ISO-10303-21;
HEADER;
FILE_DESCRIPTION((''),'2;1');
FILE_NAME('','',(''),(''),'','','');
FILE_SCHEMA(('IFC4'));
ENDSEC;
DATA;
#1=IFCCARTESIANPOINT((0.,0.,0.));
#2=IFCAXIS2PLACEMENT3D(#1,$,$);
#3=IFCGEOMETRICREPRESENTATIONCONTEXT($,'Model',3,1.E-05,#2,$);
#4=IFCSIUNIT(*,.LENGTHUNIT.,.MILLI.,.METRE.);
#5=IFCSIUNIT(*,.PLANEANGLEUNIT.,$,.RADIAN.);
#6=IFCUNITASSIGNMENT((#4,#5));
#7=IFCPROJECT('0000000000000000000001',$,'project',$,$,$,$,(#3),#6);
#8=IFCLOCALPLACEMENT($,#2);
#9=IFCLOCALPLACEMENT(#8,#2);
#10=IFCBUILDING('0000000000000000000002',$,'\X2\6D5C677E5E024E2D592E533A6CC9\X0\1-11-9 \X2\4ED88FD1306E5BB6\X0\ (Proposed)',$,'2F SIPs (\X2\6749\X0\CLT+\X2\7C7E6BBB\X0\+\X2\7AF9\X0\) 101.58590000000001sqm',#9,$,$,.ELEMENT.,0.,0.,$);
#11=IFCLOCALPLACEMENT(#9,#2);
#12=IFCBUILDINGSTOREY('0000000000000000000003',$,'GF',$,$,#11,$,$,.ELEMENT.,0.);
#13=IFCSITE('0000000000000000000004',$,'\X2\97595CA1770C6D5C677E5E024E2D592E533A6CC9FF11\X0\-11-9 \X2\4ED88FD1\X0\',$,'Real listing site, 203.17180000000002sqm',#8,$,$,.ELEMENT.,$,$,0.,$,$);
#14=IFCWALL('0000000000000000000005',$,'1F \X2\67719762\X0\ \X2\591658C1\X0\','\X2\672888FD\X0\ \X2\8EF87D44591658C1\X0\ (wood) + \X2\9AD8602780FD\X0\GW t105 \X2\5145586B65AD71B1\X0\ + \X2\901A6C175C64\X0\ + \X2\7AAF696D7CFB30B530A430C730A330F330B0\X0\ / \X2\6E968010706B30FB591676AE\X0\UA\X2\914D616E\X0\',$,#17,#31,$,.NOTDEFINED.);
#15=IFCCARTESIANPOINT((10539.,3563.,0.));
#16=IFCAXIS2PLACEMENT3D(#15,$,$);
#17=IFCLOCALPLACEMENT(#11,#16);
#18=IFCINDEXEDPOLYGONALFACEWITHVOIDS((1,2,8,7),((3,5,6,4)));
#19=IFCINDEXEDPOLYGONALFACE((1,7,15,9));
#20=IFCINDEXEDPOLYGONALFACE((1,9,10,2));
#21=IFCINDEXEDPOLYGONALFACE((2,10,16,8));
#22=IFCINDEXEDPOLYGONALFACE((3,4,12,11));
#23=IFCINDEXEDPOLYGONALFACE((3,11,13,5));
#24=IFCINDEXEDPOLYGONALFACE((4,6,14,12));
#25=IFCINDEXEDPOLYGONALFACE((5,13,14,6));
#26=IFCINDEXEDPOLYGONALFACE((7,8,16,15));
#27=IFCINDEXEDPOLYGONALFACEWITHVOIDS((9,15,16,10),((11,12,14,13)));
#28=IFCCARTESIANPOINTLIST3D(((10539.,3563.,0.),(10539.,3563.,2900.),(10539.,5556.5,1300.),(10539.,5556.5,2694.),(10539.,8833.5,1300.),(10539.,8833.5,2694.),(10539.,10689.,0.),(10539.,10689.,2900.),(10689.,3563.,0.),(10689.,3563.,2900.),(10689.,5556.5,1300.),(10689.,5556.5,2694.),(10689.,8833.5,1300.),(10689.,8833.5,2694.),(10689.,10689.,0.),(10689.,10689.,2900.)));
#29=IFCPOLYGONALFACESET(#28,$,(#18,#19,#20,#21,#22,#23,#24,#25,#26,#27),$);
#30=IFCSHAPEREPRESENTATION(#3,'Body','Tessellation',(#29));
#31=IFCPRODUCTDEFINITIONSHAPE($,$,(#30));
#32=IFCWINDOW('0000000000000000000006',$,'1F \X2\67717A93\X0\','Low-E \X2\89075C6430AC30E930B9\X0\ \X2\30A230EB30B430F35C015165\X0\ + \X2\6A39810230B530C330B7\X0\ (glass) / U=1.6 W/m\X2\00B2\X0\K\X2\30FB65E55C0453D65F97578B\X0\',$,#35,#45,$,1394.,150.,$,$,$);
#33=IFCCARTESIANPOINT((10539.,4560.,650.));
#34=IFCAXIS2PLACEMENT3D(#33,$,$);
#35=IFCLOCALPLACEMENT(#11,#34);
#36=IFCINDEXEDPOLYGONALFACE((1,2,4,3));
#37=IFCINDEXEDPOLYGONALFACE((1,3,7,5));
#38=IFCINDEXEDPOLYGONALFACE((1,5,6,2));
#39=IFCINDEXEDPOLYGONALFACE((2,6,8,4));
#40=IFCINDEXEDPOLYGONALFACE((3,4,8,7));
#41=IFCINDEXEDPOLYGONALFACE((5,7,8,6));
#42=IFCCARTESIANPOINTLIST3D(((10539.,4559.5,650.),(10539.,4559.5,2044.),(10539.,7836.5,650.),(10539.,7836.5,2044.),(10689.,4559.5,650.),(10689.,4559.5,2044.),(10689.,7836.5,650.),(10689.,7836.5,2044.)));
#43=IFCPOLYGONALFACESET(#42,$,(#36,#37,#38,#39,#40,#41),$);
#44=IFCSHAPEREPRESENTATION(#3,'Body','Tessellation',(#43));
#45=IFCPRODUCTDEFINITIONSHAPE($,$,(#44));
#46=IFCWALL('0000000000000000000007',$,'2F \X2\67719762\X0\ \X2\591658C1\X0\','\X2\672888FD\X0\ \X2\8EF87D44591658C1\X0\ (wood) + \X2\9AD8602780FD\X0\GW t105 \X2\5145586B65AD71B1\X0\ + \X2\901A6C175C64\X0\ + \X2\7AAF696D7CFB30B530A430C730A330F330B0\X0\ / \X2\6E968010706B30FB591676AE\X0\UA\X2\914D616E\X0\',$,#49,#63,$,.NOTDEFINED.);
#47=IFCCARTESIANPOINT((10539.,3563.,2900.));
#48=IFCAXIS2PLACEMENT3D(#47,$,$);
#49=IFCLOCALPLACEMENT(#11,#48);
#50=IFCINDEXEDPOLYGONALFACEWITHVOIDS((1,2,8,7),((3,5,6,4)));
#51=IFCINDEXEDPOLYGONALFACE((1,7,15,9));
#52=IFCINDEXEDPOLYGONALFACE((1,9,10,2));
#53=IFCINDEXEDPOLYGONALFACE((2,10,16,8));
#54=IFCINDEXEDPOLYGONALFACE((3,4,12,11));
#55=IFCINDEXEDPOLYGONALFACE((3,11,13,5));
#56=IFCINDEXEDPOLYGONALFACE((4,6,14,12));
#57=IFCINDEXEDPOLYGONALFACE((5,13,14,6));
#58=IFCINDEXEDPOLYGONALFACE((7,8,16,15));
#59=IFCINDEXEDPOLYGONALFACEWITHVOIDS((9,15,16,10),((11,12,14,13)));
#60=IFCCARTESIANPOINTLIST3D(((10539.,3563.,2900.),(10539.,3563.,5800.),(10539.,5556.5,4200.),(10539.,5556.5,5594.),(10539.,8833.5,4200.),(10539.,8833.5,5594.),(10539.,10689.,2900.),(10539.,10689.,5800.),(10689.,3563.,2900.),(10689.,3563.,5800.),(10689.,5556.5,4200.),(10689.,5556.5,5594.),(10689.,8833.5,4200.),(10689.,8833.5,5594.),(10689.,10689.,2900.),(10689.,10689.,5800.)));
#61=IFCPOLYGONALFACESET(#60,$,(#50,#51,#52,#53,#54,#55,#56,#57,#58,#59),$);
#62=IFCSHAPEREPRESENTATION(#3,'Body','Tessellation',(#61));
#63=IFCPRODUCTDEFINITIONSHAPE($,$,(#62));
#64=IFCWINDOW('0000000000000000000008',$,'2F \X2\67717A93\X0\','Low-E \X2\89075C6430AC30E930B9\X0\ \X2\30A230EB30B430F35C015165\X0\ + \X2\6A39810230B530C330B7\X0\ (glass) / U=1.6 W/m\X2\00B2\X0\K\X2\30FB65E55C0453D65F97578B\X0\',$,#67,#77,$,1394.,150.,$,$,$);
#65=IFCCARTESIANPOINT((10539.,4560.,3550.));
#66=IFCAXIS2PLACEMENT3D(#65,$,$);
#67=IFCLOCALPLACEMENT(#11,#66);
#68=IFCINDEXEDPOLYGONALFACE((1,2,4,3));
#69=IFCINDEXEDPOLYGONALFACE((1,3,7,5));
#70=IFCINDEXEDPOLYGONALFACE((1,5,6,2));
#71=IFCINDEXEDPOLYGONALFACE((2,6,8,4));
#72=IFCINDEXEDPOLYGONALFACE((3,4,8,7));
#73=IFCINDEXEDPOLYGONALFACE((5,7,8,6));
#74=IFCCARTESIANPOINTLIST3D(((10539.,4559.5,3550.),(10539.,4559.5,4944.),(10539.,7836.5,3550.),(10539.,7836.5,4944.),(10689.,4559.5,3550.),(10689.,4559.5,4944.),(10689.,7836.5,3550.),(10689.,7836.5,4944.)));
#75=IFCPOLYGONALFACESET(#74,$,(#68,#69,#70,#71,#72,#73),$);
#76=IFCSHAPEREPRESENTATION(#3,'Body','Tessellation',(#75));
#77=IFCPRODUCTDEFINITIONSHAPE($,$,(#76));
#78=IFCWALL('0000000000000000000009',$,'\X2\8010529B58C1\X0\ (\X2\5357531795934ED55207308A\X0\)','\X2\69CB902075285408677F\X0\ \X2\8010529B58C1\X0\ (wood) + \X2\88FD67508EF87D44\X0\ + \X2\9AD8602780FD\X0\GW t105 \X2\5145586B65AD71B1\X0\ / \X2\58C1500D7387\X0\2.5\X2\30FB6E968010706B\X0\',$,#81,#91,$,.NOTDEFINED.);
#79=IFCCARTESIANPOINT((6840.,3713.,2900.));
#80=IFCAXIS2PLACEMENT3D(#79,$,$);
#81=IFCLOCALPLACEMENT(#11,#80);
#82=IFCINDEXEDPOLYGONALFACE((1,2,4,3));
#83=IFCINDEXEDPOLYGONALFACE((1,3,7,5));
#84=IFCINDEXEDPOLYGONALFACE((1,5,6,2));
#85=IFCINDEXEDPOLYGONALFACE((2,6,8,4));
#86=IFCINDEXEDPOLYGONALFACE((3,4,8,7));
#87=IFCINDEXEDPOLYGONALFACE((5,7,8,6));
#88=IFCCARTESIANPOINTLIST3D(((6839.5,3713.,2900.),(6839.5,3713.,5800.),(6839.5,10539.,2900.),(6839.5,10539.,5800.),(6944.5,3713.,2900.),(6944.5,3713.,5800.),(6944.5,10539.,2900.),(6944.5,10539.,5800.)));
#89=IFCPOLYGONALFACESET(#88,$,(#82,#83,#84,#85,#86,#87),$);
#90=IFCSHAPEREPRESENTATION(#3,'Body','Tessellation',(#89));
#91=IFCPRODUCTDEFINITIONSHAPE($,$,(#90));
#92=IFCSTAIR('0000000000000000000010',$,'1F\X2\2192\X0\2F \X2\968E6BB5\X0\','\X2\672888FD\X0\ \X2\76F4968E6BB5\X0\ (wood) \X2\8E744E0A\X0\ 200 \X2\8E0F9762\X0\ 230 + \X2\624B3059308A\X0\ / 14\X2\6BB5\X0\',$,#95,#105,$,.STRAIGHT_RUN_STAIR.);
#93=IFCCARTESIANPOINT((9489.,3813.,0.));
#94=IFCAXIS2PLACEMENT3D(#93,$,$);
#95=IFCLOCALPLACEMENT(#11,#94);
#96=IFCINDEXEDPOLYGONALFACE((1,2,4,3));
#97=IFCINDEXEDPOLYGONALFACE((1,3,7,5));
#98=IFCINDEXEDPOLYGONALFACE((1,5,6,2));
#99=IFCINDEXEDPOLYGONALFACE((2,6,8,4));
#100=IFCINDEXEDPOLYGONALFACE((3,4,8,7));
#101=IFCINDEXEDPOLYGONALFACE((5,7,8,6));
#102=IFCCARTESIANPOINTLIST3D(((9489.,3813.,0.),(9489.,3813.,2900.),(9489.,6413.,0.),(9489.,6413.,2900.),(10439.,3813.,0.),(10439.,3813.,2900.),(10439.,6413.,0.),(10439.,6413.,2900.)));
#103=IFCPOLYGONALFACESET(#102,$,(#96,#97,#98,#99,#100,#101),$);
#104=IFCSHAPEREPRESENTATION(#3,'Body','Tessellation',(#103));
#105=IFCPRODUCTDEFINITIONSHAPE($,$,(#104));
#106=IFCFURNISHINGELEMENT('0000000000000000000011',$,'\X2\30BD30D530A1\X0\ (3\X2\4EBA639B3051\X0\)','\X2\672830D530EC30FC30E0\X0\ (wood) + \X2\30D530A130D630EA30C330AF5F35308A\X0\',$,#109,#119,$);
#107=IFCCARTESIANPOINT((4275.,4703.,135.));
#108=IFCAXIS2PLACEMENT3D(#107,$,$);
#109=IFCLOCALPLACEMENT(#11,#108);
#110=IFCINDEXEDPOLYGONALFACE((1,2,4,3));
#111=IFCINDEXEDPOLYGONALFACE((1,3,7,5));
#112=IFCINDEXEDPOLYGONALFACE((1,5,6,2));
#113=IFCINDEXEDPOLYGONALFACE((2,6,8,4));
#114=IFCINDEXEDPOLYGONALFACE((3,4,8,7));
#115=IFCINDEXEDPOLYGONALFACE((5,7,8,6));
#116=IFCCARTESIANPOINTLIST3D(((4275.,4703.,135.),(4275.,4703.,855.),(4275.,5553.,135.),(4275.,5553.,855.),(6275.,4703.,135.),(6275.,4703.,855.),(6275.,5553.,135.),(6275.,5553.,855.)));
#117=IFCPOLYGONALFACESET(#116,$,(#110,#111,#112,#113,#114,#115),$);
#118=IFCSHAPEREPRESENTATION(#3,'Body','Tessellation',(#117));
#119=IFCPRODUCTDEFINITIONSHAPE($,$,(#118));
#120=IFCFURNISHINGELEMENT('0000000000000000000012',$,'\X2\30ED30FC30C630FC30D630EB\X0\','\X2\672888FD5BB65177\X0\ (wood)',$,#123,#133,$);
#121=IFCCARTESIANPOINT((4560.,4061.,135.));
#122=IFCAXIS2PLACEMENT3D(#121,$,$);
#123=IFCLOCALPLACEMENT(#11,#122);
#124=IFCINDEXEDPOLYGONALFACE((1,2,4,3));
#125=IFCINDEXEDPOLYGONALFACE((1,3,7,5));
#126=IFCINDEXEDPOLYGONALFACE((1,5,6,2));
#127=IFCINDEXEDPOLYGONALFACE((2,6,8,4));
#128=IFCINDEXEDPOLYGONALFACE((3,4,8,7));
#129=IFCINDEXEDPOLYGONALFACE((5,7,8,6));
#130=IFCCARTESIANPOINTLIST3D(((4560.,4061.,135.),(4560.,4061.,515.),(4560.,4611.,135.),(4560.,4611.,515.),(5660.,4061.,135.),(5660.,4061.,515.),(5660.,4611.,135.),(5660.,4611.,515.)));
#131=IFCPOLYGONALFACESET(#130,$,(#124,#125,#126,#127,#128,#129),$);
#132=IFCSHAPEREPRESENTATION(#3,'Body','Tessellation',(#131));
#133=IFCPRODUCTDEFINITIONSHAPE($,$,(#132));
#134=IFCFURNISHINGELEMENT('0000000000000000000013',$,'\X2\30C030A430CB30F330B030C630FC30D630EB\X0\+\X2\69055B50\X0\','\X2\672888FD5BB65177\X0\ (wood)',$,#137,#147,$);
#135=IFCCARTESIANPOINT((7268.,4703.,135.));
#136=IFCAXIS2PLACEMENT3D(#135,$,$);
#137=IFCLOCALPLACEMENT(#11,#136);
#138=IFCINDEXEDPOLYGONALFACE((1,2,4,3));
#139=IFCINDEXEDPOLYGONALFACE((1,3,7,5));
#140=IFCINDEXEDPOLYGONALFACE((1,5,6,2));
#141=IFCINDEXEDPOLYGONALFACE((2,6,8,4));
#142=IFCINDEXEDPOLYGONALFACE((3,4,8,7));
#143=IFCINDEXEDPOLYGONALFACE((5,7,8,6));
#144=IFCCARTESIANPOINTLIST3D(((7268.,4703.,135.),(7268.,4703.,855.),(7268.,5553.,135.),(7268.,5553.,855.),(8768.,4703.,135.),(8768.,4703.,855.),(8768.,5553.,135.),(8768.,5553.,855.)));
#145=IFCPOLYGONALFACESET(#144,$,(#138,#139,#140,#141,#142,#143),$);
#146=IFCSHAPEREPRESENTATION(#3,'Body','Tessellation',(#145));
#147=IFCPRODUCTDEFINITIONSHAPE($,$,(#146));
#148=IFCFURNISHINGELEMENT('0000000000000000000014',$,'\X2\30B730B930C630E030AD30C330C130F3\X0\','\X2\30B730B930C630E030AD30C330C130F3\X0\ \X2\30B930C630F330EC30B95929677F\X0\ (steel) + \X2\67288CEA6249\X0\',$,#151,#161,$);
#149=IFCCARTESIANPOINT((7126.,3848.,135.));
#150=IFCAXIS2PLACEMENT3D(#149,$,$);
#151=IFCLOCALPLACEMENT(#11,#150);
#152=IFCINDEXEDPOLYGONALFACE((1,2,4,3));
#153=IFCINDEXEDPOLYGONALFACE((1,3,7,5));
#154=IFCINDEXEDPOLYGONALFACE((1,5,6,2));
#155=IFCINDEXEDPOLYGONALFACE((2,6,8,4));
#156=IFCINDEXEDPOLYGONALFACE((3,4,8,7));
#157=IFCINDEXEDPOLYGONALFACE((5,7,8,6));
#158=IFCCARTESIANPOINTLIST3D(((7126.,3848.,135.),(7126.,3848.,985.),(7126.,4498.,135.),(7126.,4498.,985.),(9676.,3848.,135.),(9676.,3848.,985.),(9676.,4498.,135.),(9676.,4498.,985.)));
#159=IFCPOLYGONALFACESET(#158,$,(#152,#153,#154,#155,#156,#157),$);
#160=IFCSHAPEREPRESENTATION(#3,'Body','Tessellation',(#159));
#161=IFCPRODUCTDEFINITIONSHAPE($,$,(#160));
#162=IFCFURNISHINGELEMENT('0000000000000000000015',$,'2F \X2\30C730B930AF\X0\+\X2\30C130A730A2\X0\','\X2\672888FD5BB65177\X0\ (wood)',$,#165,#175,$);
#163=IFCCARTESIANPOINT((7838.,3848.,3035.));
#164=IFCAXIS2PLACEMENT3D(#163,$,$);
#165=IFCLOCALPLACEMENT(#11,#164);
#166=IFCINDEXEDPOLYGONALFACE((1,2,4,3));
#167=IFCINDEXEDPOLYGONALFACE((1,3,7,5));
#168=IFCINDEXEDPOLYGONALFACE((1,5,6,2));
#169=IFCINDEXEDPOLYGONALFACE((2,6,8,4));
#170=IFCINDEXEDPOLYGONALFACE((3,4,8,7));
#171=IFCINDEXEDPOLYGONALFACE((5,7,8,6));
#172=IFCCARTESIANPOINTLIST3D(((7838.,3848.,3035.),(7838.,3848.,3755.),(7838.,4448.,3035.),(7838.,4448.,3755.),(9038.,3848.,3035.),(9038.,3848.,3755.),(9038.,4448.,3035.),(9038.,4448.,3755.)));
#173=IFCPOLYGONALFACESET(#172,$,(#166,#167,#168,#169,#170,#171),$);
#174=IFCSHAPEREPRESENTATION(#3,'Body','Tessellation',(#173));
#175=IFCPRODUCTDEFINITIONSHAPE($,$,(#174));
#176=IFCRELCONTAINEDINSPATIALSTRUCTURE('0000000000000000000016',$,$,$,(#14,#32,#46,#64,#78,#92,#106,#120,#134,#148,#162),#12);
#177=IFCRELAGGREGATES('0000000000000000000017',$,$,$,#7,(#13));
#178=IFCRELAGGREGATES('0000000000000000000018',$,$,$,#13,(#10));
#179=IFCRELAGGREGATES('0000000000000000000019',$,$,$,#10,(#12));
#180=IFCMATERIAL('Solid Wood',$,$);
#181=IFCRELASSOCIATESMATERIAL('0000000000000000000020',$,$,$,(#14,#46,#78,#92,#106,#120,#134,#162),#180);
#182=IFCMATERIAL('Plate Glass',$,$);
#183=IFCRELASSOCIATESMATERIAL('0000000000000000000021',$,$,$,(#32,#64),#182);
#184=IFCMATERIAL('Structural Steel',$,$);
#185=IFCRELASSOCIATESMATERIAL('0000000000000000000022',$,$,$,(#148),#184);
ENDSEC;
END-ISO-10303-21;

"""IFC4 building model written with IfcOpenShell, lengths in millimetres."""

from ifc_helpers import new_model, si_unit, frame, frame_2d, origin, place, context, project, spatial, rectangle, extrude, material, element, fill, save


model = new_model("IFC4")

# Units and contexts
model_context = context("Model", 3, precision=1e-05, world=origin())
ifc_project = project(units=[si_unit("LENGTHUNIT", "METRE", prefix="MILLI"), si_unit("PLANEANGLEUNIT", "RADIAN")], contexts=[model_context])

# Site, building, storey
site_placement = place(None, origin())
site = spatial("IfcSite", under=ifc_project, at=site_placement, Name="静岡県浜松市中央区泉１-11-9 付近", ObjectType="Real listing site, 203.17180000000002sqm", CompositionType="ELEMENT", RefElevation=0.0)
building_placement = place(site_placement, origin())
building = spatial("IfcBuilding", under=site, at=building_placement, Name="浜松市中央区泉1-11-9 付近の家 (Proposed)", ObjectType="2F SIPs (杉CLT+籾殻+竹) 101.58590000000001sqm", CompositionType="ELEMENT", ElevationOfRefHeight=0.0, ElevationOfTerrain=0.0)
storey_placement = place(building_placement, origin())
storey = spatial("IfcBuildingStorey", under=building, at=storey_placement, Name="GF", CompositionType="ELEMENT", Elevation=0.0)

# Wall, opening, window
ifc_material_1 = material(Name="Solid Wood")
wall_1_placement = place(storey_placement, frame((10539.0, 3563.0, 0.0)))
wall_1 = element("IfcWall", 1, at=wall_1_placement, inside=storey, material=ifc_material_1, Name="1F 東面 外壁", Description="木製 軸組外壁 (wood) + 高性能GW t105 充填断熱 + 通気層 + 窯業系サイディング / 準耐火・外皮UA配慮", PredefinedType="NOTDEFINED", context=model_context, shape_type="SweptSolid", body=[
    extrude(rectangle(XDim=150.0, YDim=7126.0, at=frame_2d((75.0, 3563.0))), frame((10539.0, 3563.0, 0.0)), (0.0, 0.0, 1.0), 2900.0),
])
opening_1_placement = place(storey_placement, frame((10539.0, 4560.0, 650.0)))
opening_1 = element("IfcOpeningElement", 2, at=opening_1_placement, cuts=wall_1, PredefinedType="NOTDEFINED", context=model_context, shape_type="SweptSolid", body=[
    extrude(rectangle(XDim=150.0, YDim=3277.0, at=frame_2d((75.0, 1638.0))), frame((10539.0, 4560.0, 650.0)), (0.0, 0.0, 1.0), 1394.0),
])
ifc_material_2 = material(Name="Plate Glass")
window_1_placement = place(storey_placement, frame((10539.0, 4560.0, 650.0)))
window_1 = element("IfcWindow", 3, at=window_1_placement, inside=storey, material=ifc_material_2, Name="1F 東窓", Description="Low-E 複層ガラス アルゴン封入 + 樹脂サッシ (glass) / U=1.6 W/m²K・日射取得型", OverallHeight=1394.0, OverallWidth=150.0, context=model_context, shape_type="SweptSolid", body=[
    extrude(rectangle(XDim=150.0, YDim=3277.0, at=frame_2d((75.0, 1638.0))), frame((10539.0, 4560.0, 650.0)), (0.0, 0.0, 1.0), 1394.0),
])
fill(opening_1, window_1)

# Wall, opening, window
wall_2_placement = place(storey_placement, frame((10539.0, 3563.0, 2900.0)))
wall_2 = element("IfcWall", 4, at=wall_2_placement, inside=storey, material=ifc_material_1, Name="2F 東面 外壁", Description="木製 軸組外壁 (wood) + 高性能GW t105 充填断熱 + 通気層 + 窯業系サイディング / 準耐火・外皮UA配慮", PredefinedType="NOTDEFINED", context=model_context, shape_type="SweptSolid", body=[
    extrude(rectangle(XDim=150.0, YDim=7126.0, at=frame_2d((75.0, 3563.0))), frame((10539.0, 3563.0, 2900.0)), (0.0, 0.0, 1.0), 2900.0),
])
opening_2_placement = place(storey_placement, frame((10539.0, 4560.0, 3550.0)))
opening_2 = element("IfcOpeningElement", 5, at=opening_2_placement, cuts=wall_2, PredefinedType="NOTDEFINED", context=model_context, shape_type="SweptSolid", body=[
    extrude(rectangle(XDim=150.0, YDim=3277.0, at=frame_2d((75.0, 1638.0))), frame((10539.0, 4560.0, 3550.0)), (0.0, 0.0, 1.0), 1394.0),
])
window_2_placement = place(storey_placement, frame((10539.0, 4560.0, 3550.0)))
window_2 = element("IfcWindow", 6, at=window_2_placement, inside=storey, material=ifc_material_2, Name="2F 東窓", Description="Low-E 複層ガラス アルゴン封入 + 樹脂サッシ (glass) / U=1.6 W/m²K・日射取得型", OverallHeight=1394.0, OverallWidth=150.0, context=model_context, shape_type="SweptSolid", body=[
    extrude(rectangle(XDim=150.0, YDim=3277.0, at=frame_2d((75.0, 1638.0))), frame((10539.0, 4560.0, 3550.0)), (0.0, 0.0, 1.0), 1394.0),
])
fill(opening_2, window_2)

# Wall
wall_3_placement = place(storey_placement, frame((6840.0, 3713.0, 2900.0)))
element("IfcWall", 7, at=wall_3_placement, inside=storey, material=ifc_material_1, Name="耐力壁 (南北間仕切り)", Description="構造用合板 耐力壁 (wood) + 製材軸組 + 高性能GW t105 充填断熱 / 壁倍率2.5・準耐火", PredefinedType="NOTDEFINED", context=model_context, shape_type="SweptSolid", body=[
    extrude(rectangle(XDim=105.0, YDim=6826.0, at=frame_2d((52.0, 3413.0))), frame((6840.0, 3713.0, 2900.0)), (0.0, 0.0, 1.0), 2900.0),
])

# Stair
stair_placement = place(storey_placement, frame((9489.0, 3813.0, 0.0)))
element("IfcStair", 8, at=stair_placement, inside=storey, material=ifc_material_1, Name="1F→2F 階段", Description="木製 直階段 (wood) 蹴上 200 踏面 230 + 手すり / 14段", PredefinedType="STRAIGHT_RUN_STAIR", context=model_context, shape_type="SweptSolid", body=[
    extrude(rectangle(XDim=950.0, YDim=2600.0, at=frame_2d((475.0, 1300.0))), frame((9489.0, 3813.0, 0.0)), (0.0, 0.0, 1.0), 2900.0),
])

# Furnishing elements
furnishing_1_placement = place(storey_placement, frame((4275.0, 4703.0, 135.0)))
element("IfcFurnishingElement", 9, at=furnishing_1_placement, inside=storey, material=ifc_material_1, Name="ソファ (3人掛け)", Description="木フレーム (wood) + ファブリック張り", context=model_context, shape_type="SweptSolid", body=[
    extrude(rectangle(XDim=2000.0, YDim=850.0, at=frame_2d((1000.0, 425.0))), frame((4275.0, 4703.0, 135.0)), (0.0, 0.0, 1.0), 720.0),
])
furnishing_2_placement = place(storey_placement, frame((4560.0, 4061.0, 135.0)))
element("IfcFurnishingElement", 10, at=furnishing_2_placement, inside=storey, material=ifc_material_1, Name="ローテーブル", Description="木製家具 (wood)", context=model_context, shape_type="SweptSolid", body=[
    extrude(rectangle(XDim=1100.0, YDim=550.0, at=frame_2d((550.0, 275.0))), frame((4560.0, 4061.0, 135.0)), (0.0, 0.0, 1.0), 380.0),
])
furnishing_3_placement = place(storey_placement, frame((7268.0, 4703.0, 135.0)))
element("IfcFurnishingElement", 11, at=furnishing_3_placement, inside=storey, material=ifc_material_1, Name="ダイニングテーブル+椅子", Description="木製家具 (wood)", context=model_context, shape_type="SweptSolid", body=[
    extrude(rectangle(XDim=1500.0, YDim=850.0, at=frame_2d((750.0, 425.0))), frame((7268.0, 4703.0, 135.0)), (0.0, 0.0, 1.0), 720.0),
])
ifc_material_3 = material(Name="Structural Steel")
furnishing_4_placement = place(storey_placement, frame((7126.0, 3848.0, 135.0)))
element("IfcFurnishingElement", 12, at=furnishing_4_placement, inside=storey, material=ifc_material_3, Name="システムキッチン", Description="システムキッチン ステンレス天板 (steel) + 木質扉", context=model_context, shape_type="SweptSolid", body=[
    extrude(rectangle(XDim=2550.0, YDim=650.0, at=frame_2d((1275.0, 325.0))), frame((7126.0, 3848.0, 135.0)), (0.0, 0.0, 1.0), 850.0),
])
furnishing_5_placement = place(storey_placement, frame((7838.0, 3848.0, 3035.0)))
element("IfcFurnishingElement", 13, at=furnishing_5_placement, inside=storey, material=ifc_material_1, Name="2F デスク+チェア", Description="木製家具 (wood)", context=model_context, shape_type="SweptSolid", body=[
    extrude(rectangle(XDim=1200.0, YDim=600.0, at=frame_2d((600.0, 300.0))), frame((7838.0, 3848.0, 3035.0)), (0.0, 0.0, 1.0), 720.0),
])

save(model, "model.ifc")
